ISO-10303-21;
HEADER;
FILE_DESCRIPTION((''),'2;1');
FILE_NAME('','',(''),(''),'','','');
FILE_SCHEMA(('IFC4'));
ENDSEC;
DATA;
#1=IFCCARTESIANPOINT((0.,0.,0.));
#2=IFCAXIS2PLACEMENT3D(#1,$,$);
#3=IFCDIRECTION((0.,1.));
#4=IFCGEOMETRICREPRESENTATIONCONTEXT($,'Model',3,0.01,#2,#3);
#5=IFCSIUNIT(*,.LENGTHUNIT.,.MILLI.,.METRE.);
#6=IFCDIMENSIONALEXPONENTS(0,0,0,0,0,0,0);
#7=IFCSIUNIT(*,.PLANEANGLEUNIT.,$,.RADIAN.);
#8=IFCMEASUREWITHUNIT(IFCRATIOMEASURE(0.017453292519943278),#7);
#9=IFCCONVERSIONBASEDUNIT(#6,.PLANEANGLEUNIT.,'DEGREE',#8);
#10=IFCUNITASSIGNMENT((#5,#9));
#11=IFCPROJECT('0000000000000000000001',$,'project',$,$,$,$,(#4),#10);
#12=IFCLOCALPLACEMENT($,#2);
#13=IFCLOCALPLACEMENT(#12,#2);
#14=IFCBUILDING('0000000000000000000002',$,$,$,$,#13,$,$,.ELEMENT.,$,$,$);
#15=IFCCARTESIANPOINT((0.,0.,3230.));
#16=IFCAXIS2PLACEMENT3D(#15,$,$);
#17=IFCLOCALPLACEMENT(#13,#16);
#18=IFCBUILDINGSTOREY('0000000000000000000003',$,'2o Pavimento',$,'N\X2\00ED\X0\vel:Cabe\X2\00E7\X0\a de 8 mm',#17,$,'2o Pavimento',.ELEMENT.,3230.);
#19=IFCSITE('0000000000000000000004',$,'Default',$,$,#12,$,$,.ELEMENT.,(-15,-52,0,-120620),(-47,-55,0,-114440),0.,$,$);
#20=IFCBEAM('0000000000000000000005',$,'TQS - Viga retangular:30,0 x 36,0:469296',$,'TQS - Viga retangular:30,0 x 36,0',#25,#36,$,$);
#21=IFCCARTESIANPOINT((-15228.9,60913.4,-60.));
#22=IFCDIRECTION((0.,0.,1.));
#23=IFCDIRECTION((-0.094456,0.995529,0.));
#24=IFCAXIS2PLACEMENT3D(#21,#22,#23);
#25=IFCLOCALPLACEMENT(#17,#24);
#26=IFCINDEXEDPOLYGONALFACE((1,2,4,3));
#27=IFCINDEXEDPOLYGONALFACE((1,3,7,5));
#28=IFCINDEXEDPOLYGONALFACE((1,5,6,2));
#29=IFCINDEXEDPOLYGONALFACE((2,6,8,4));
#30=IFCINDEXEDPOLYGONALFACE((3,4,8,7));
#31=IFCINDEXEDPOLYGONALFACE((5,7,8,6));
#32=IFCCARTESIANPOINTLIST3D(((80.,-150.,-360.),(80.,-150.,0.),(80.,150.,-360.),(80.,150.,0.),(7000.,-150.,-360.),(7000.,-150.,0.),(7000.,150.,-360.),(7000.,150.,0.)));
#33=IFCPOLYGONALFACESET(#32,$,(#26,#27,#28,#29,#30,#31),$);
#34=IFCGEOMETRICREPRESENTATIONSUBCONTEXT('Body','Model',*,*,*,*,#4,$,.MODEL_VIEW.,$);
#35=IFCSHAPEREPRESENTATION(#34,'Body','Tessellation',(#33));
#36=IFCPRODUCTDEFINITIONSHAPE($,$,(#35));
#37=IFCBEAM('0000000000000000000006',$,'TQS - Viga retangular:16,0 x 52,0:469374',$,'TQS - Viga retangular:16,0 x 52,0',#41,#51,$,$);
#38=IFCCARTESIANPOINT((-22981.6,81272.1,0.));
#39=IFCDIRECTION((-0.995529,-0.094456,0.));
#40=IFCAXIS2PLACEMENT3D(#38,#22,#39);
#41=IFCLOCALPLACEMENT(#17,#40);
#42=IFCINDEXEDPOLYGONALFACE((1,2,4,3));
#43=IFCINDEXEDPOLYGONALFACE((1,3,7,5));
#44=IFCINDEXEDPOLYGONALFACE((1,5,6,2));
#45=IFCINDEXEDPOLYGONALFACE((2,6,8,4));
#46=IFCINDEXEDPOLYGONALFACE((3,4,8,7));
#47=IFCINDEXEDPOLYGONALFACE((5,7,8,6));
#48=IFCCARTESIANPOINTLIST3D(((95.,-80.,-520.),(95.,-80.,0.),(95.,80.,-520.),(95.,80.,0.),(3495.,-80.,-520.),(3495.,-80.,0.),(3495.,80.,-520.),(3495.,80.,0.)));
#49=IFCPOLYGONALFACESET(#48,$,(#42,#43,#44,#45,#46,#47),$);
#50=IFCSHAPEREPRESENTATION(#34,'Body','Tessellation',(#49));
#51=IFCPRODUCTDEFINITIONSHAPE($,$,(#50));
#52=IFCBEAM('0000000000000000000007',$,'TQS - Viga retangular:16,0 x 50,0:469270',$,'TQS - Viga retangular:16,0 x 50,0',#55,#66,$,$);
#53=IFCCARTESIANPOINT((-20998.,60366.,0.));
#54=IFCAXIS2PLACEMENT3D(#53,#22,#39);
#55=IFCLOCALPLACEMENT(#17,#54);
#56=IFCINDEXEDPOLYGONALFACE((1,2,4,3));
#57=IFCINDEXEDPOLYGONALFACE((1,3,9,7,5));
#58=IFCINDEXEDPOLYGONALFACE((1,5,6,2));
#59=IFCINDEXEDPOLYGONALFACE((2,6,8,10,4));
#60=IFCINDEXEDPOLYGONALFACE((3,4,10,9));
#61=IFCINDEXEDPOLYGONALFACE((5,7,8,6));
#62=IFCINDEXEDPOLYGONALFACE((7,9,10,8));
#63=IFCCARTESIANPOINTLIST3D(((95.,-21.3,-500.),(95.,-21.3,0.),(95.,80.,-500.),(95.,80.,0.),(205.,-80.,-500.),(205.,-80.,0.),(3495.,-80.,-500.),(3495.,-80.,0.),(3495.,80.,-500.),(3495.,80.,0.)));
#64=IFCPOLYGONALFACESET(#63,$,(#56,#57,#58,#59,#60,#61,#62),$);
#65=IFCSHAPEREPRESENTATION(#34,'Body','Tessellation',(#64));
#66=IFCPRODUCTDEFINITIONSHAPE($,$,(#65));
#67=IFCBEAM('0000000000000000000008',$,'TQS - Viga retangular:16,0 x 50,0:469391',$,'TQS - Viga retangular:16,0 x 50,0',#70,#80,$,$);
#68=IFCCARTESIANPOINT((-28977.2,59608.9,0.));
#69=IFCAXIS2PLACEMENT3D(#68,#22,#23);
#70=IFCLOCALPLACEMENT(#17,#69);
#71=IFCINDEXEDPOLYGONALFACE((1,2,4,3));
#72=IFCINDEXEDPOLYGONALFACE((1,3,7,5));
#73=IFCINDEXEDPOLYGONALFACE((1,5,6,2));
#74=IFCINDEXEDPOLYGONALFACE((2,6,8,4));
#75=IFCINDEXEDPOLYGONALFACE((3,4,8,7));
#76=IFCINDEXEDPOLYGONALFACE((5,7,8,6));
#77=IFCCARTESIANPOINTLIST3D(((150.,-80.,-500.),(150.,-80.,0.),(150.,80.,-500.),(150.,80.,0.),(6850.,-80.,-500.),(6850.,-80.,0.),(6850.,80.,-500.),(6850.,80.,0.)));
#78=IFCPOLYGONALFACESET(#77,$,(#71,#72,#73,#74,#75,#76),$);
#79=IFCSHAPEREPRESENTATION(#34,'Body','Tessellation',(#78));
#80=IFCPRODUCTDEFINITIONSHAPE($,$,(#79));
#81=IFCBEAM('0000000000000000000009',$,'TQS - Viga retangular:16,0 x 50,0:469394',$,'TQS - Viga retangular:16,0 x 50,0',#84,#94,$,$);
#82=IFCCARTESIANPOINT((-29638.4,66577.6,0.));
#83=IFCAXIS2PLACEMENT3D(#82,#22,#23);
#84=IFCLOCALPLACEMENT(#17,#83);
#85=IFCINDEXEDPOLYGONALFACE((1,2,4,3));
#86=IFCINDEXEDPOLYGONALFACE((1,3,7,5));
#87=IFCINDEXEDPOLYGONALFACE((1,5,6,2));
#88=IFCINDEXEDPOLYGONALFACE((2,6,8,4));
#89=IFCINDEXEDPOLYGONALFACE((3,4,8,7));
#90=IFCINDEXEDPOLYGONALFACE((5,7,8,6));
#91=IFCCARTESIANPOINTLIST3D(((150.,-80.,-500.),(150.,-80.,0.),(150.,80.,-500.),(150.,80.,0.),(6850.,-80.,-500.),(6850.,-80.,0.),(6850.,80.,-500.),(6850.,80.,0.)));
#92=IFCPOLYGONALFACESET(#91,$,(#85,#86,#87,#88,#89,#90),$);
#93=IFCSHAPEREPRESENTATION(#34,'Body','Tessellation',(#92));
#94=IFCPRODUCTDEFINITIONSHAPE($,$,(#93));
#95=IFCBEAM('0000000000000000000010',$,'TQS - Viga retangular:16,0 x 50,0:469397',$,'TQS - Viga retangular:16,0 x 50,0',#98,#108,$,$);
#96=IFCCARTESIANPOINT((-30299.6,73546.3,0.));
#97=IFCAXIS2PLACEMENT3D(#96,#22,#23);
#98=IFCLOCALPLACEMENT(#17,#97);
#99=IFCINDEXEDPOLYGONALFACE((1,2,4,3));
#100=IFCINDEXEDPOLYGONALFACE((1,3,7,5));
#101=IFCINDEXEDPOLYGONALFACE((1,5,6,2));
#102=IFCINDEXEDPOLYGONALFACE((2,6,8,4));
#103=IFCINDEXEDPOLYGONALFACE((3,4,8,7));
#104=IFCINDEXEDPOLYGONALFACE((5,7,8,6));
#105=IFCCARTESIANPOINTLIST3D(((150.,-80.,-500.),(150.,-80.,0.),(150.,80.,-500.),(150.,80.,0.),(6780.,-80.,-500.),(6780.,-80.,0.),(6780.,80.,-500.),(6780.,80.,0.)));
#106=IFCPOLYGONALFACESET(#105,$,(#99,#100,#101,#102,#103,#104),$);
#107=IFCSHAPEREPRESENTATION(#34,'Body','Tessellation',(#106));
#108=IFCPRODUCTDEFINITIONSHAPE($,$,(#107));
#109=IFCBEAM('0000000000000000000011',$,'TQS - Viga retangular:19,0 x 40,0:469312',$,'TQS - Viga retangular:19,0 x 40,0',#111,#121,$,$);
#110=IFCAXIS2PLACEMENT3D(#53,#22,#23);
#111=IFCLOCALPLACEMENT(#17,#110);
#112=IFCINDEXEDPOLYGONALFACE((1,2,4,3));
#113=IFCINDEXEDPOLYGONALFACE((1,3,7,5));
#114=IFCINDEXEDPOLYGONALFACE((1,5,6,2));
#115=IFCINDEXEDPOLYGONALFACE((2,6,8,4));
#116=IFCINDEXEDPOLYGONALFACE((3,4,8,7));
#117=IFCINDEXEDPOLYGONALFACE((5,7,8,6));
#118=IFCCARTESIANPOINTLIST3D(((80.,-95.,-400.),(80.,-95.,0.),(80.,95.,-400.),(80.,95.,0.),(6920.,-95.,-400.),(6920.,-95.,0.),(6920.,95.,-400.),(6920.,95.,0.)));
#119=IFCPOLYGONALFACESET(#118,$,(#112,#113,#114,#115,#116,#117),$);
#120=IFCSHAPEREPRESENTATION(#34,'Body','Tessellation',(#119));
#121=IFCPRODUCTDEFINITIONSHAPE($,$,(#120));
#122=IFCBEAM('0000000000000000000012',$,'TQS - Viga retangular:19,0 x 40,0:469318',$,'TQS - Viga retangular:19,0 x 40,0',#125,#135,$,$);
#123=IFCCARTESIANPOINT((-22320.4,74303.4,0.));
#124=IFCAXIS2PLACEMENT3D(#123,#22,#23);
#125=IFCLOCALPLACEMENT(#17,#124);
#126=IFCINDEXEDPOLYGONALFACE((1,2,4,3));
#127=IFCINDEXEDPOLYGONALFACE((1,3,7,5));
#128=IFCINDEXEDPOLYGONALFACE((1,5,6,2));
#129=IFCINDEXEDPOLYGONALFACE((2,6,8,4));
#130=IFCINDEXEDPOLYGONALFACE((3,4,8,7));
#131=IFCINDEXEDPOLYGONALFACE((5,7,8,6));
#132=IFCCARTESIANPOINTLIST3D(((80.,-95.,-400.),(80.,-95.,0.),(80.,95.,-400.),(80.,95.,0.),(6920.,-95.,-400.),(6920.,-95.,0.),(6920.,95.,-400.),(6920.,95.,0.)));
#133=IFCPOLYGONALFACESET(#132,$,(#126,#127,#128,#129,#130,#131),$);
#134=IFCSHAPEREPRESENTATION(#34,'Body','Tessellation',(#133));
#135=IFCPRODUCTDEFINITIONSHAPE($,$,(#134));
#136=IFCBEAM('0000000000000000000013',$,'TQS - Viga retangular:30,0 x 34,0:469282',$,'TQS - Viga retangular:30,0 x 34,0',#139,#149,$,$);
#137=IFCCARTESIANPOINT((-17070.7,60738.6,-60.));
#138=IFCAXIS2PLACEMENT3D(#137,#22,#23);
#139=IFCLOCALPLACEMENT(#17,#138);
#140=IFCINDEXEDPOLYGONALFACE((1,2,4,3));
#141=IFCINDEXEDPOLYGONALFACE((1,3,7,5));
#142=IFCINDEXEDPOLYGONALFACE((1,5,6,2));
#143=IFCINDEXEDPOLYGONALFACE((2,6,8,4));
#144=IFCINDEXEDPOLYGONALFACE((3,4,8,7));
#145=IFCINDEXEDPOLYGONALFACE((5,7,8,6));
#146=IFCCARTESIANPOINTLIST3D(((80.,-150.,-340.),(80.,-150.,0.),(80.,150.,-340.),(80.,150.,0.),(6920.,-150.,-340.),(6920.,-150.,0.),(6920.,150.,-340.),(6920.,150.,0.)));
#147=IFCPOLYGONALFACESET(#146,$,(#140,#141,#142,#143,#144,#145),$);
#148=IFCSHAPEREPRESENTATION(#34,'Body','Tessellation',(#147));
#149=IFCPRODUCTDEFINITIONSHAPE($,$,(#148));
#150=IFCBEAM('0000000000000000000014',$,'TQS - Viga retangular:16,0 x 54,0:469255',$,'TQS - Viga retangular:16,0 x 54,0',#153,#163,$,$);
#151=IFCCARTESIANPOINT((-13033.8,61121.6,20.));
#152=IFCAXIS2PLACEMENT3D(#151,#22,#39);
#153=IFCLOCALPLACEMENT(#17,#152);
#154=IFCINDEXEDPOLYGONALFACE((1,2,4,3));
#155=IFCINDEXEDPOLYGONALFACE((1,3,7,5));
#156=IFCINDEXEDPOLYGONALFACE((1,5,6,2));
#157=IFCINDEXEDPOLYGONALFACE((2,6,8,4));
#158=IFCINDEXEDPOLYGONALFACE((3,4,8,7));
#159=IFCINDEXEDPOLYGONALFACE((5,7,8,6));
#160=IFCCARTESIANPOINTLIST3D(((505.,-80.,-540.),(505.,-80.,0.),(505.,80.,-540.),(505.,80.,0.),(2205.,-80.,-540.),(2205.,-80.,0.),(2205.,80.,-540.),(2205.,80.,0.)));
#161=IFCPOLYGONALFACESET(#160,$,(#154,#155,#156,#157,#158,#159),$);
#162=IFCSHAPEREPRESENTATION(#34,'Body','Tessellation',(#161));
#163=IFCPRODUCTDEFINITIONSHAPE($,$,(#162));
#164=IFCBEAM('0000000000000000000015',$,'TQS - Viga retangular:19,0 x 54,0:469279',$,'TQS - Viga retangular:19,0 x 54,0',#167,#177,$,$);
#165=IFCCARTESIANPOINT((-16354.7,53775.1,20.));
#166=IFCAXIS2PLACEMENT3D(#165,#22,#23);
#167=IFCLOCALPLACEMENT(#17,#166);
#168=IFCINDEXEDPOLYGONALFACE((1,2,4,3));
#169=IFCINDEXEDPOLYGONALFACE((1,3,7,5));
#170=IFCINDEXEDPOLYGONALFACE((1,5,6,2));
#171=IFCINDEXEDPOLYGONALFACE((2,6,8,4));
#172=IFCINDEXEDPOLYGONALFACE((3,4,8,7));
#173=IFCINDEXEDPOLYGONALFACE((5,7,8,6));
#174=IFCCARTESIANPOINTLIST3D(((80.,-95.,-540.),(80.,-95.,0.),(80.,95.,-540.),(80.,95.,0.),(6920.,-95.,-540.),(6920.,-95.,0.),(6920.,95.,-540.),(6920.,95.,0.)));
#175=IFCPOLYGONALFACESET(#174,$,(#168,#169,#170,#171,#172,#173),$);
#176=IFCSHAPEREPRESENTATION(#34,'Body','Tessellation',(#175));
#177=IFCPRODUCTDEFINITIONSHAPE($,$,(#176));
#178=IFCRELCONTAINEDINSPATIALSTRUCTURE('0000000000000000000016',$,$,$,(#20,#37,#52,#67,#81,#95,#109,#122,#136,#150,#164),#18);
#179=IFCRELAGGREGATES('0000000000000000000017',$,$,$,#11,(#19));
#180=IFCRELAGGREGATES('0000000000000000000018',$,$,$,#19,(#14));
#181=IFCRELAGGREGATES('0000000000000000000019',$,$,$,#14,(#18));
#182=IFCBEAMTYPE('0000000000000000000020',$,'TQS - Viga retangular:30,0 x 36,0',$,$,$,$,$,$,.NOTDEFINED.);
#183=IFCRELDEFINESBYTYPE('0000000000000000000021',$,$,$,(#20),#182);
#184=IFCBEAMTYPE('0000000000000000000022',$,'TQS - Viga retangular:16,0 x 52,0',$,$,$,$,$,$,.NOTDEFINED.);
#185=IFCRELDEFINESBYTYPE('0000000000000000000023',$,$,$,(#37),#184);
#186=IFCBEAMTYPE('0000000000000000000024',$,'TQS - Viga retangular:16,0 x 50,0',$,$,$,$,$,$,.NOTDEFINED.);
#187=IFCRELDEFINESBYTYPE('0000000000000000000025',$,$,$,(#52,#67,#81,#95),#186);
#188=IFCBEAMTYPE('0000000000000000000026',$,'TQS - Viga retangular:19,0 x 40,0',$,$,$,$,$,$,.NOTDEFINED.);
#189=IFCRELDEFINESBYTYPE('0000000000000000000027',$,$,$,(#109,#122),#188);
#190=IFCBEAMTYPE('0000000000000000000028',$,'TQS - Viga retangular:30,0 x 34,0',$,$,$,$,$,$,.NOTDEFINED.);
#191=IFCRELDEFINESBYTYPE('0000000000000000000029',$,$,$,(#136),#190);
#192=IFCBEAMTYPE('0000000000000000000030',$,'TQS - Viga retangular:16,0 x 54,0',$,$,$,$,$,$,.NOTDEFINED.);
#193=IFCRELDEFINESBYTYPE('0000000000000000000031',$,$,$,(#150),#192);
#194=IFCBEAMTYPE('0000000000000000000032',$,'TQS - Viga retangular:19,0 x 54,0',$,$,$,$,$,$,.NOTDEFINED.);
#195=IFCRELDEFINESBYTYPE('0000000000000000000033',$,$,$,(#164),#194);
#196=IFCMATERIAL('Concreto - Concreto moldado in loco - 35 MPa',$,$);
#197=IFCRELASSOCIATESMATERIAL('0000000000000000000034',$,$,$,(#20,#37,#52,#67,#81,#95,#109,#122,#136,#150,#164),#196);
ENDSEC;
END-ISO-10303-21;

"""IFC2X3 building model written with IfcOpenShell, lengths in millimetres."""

from ifc_helpers import new_model, entity, si_unit, converted_unit, direction, frame, frame_2d, origin, origin_2d_with_axis, place, context, subcontext, project, spatial, rectangle, extrude, clip, halfspace, material, type_object, element, save


model = new_model("IFC2X3")

# Units and contexts
model_context = context("Model", 3, precision=0.01, world=origin(), true_north=direction((0.0, 1.0)))
body_context = subcontext(model_context, "Body", "Model", "MODEL_VIEW")
ifc_project = project(units=[si_unit("LENGTHUNIT", "METRE", prefix="MILLI"), converted_unit("PLANEANGLEUNIT", "DEGREE", entity("IfcRatioMeasure", 0.017453292519943278), si_unit("PLANEANGLEUNIT", "RADIAN"), dimensions=[0, 0, 0, 0, 0, 0, 0])], contexts=[model_context])

# Site, building, storey
site_placement = place(None, origin())
site = spatial("IfcSite", under=ifc_project, at=site_placement, Name="Default", CompositionType="ELEMENT", RefLatitude=(-15, -52, 0, -120620), RefLongitude=(-47, -55, 0, -114440), RefElevation=0.0)
building_placement = place(site_placement, origin())
building = spatial("IfcBuilding", under=site, at=building_placement, CompositionType="ELEMENT")
storey_placement = place(building_placement, frame((0.0, 0.0, 3230.0)))
storey = spatial("IfcBuildingStorey", under=building, at=storey_placement, Name="2o Pavimento", ObjectType="Nível:Cabeça de 8 mm", LongName="2o Pavimento", CompositionType="ELEMENT", Elevation=3230.0)

# Beams
ifc_material = material(Name="Concreto - Concreto moldado in loco - 35 MPa")
beam_type_1 = type_object("IfcBeamType", Name="TQS - Viga retangular:30,0 x 36,0", PredefinedType="NOTDEFINED")
beam_1_placement = place(storey_placement, frame((-15228.9, 60913.4, -60.0), z_axis=(0.0, 0.0, 1.0), x_axis=(-0.094456, 0.995529, 0.0)))
element("IfcBeam", 1, at=beam_1_placement, inside=storey, type_object=beam_type_1, material=ifc_material, Name="TQS - Viga retangular:30,0 x 36,0:469296", ObjectType="TQS - Viga retangular:30,0 x 36,0", context=body_context, shape_type="SweptSolid", body=[
    extrude(rectangle(XDim=360.0, YDim=300.0, at=frame_2d((0.0, 0.0), x_axis=(1.0, 0.0))), frame((80.0, 0.0, -180.0), z_axis=(1.0, 0.0, 0.0), x_axis=(0.0, 0.0, -1.0)), (0.0, 0.0, 1.0), 6920.0),
])
beam_type_2 = type_object("IfcBeamType", Name="TQS - Viga retangular:16,0 x 52,0", PredefinedType="NOTDEFINED")
beam_2_placement = place(storey_placement, frame((-22981.6, 81272.1, 0.0), z_axis=(0.0, 0.0, 1.0), x_axis=(-0.995529, -0.094456, 0.0)))
element("IfcBeam", 2, at=beam_2_placement, inside=storey, type_object=beam_type_2, material=ifc_material, Name="TQS - Viga retangular:16,0 x 52,0:469374", ObjectType="TQS - Viga retangular:16,0 x 52,0", context=body_context, shape_type="SweptSolid", body=[
    extrude(rectangle(XDim=520.0, YDim=160.0, at=frame_2d((0.0, 0.0), x_axis=(1.0, 0.0))), frame((95.0, 0.0, -260.0), z_axis=(1.0, 0.0, 0.0), x_axis=(0.0, 0.0, -1.0)), (0.0, 0.0, 1.0), 3400.0),
])
beam_type_3 = type_object("IfcBeamType", Name="TQS - Viga retangular:16,0 x 50,0", PredefinedType="NOTDEFINED")
beam_3_placement = place(storey_placement, frame((-20998.0, 60366.0, 0.0), z_axis=(0.0, 0.0, 1.0), x_axis=(-0.995529, -0.094456, 0.0)))
element("IfcBeam", 3, at=beam_3_placement, inside=storey, type_object=beam_type_3, material=ifc_material, Name="TQS - Viga retangular:16,0 x 50,0:469270", ObjectType="TQS - Viga retangular:16,0 x 50,0", context=body_context, shape_type="SweptSolid", body=[
    clip(extrude(rectangle(XDim=500.0, YDim=160.0, at=frame_2d((0.0, 0.0), x_axis=(1.0, 0.0))), frame((95.0, 0.0, -250.0), z_axis=(1.0, 0.0, 0.0), x_axis=(0.0, 0.0, -1.0)), (0.0, 0.0, 1.0), 3400.0), halfspace(frame((-95.0, 80.0, 0.0), z_axis=(-0.470588, -0.882353, 0.0), x_axis=(-0.882353, 0.470588, 0.0)), False)),
])
beam_4_placement = place(storey_placement, frame((-28977.2, 59608.9, 0.0), z_axis=(0.0, 0.0, 1.0), x_axis=(-0.094456, 0.995529, 0.0)))
element("IfcBeam", 4, at=beam_4_placement, inside=storey, type_object=beam_type_3, material=ifc_material, Name="TQS - Viga retangular:16,0 x 50,0:469391", ObjectType="TQS - Viga retangular:16,0 x 50,0", context=body_context, shape_type="SweptSolid", body=[
    extrude(rectangle(XDim=500.0, YDim=160.0, at=origin_2d_with_axis()), frame((150.0, 0.0, -250.0), z_axis=(1.0, 0.0, 0.0), x_axis=(0.0, 0.0, -1.0)), (0.0, 0.0, 1.0), 6700.0),
])
beam_5_placement = place(storey_placement, frame((-29638.4, 66577.6, 0.0), z_axis=(0.0, 0.0, 1.0), x_axis=(-0.094456, 0.995529, 0.0)))
element("IfcBeam", 5, at=beam_5_placement, inside=storey, type_object=beam_type_3, material=ifc_material, Name="TQS - Viga retangular:16,0 x 50,0:469394", ObjectType="TQS - Viga retangular:16,0 x 50,0", context=body_context, shape_type="SweptSolid", body=[
    extrude(rectangle(XDim=500.0, YDim=160.0, at=origin_2d_with_axis()), frame((150.0, 0.0, -250.0), z_axis=(1.0, 0.0, 0.0), x_axis=(0.0, 0.0, -1.0)), (0.0, 0.0, 1.0), 6700.0),
])
beam_6_placement = place(storey_placement, frame((-30299.6, 73546.3, 0.0), z_axis=(0.0, 0.0, 1.0), x_axis=(-0.094456, 0.995529, 0.0)))
element("IfcBeam", 6, at=beam_6_placement, inside=storey, type_object=beam_type_3, material=ifc_material, Name="TQS - Viga retangular:16,0 x 50,0:469397", ObjectType="TQS - Viga retangular:16,0 x 50,0", context=body_context, shape_type="SweptSolid", body=[
    extrude(rectangle(XDim=500.0, YDim=160.0, at=frame_2d((0.0, 0.0), x_axis=(1.0, 0.0))), frame((150.0, 0.0, -250.0), z_axis=(1.0, 0.0, 0.0), x_axis=(0.0, 0.0, -1.0)), (0.0, 0.0, 1.0), 6630.0),
])
beam_type_4 = type_object("IfcBeamType", Name="TQS - Viga retangular:19,0 x 40,0", PredefinedType="NOTDEFINED")
beam_7_placement = place(storey_placement, frame((-20998.0, 60366.0, 0.0), z_axis=(0.0, 0.0, 1.0), x_axis=(-0.094456, 0.995529, 0.0)))
element("IfcBeam", 7, at=beam_7_placement, inside=storey, type_object=beam_type_4, material=ifc_material, Name="TQS - Viga retangular:19,0 x 40,0:469312", ObjectType="TQS - Viga retangular:19,0 x 40,0", context=body_context, shape_type="SweptSolid", body=[
    extrude(rectangle(XDim=400.0, YDim=190.0, at=frame_2d((0.0, 0.0), x_axis=(1.0, 0.0))), frame((80.0, 0.0, -200.0), z_axis=(1.0, 0.0, 0.0), x_axis=(0.0, 0.0, -1.0)), (0.0, 0.0, 1.0), 6840.0),
])
beam_8_placement = place(storey_placement, frame((-22320.4, 74303.4, 0.0), z_axis=(0.0, 0.0, 1.0), x_axis=(-0.094456, 0.995529, 0.0)))
element("IfcBeam", 8, at=beam_8_placement, inside=storey, type_object=beam_type_4, material=ifc_material, Name="TQS - Viga retangular:19,0 x 40,0:469318", ObjectType="TQS - Viga retangular:19,0 x 40,0", context=body_context, shape_type="SweptSolid", body=[
    extrude(rectangle(XDim=400.0, YDim=190.0, at=frame_2d((0.0, 0.0), x_axis=(1.0, 0.0))), frame((80.0, 0.0, -200.0), z_axis=(1.0, 0.0, 0.0), x_axis=(0.0, 0.0, -1.0)), (0.0, 0.0, 1.0), 6840.0),
])
beam_type_5 = type_object("IfcBeamType", Name="TQS - Viga retangular:30,0 x 34,0", PredefinedType="NOTDEFINED")
beam_9_placement = place(storey_placement, frame((-17070.7, 60738.6, -60.0), z_axis=(0.0, 0.0, 1.0), x_axis=(-0.094456, 0.995529, 0.0)))
element("IfcBeam", 9, at=beam_9_placement, inside=storey, type_object=beam_type_5, material=ifc_material, Name="TQS - Viga retangular:30,0 x 34,0:469282", ObjectType="TQS - Viga retangular:30,0 x 34,0", context=body_context, shape_type="SweptSolid", body=[
    extrude(rectangle(XDim=340.0, YDim=300.0, at=frame_2d((0.0, 0.0), x_axis=(1.0, 0.0))), frame((80.0, 0.0, -170.0), z_axis=(1.0, 0.0, 0.0), x_axis=(0.0, 0.0, -1.0)), (0.0, 0.0, 1.0), 6840.0),
])
beam_type_6 = type_object("IfcBeamType", Name="TQS - Viga retangular:16,0 x 54,0", PredefinedType="NOTDEFINED")
beam_10_placement = place(storey_placement, frame((-13033.8, 61121.6, 20.0), z_axis=(0.0, 0.0, 1.0), x_axis=(-0.995529, -0.094456, 0.0)))
element("IfcBeam", 10, at=beam_10_placement, inside=storey, type_object=beam_type_6, material=ifc_material, Name="TQS - Viga retangular:16,0 x 54,0:469255", ObjectType="TQS - Viga retangular:16,0 x 54,0", context=body_context, shape_type="SweptSolid", body=[
    extrude(rectangle(XDim=540.0, YDim=160.0, at=frame_2d((0.0, 0.0), x_axis=(1.0, 0.0))), frame((505.0, 0.0, -270.0), z_axis=(1.0, 0.0, 0.0), x_axis=(0.0, 0.0, -1.0)), (0.0, 0.0, 1.0), 1700.0),
])
beam_type_7 = type_object("IfcBeamType", Name="TQS - Viga retangular:19,0 x 54,0", PredefinedType="NOTDEFINED")
beam_11_placement = place(storey_placement, frame((-16354.7, 53775.1, 20.0), z_axis=(0.0, 0.0, 1.0), x_axis=(-0.094456, 0.995529, 0.0)))
element("IfcBeam", 11, at=beam_11_placement, inside=storey, type_object=beam_type_7, material=ifc_material, Name="TQS - Viga retangular:19,0 x 54,0:469279", ObjectType="TQS - Viga retangular:19,0 x 54,0", context=body_context, shape_type="SweptSolid", body=[
    extrude(rectangle(XDim=540.0, YDim=190.0, at=frame_2d((0.0, 0.0), x_axis=(1.0, 0.0))), frame((80.0, 0.0, -270.0), z_axis=(1.0, 0.0, 0.0), x_axis=(0.0, 0.0, -1.0)), (0.0, 0.0, 1.0), 6840.0),
])

save(model, "model.ifc")
